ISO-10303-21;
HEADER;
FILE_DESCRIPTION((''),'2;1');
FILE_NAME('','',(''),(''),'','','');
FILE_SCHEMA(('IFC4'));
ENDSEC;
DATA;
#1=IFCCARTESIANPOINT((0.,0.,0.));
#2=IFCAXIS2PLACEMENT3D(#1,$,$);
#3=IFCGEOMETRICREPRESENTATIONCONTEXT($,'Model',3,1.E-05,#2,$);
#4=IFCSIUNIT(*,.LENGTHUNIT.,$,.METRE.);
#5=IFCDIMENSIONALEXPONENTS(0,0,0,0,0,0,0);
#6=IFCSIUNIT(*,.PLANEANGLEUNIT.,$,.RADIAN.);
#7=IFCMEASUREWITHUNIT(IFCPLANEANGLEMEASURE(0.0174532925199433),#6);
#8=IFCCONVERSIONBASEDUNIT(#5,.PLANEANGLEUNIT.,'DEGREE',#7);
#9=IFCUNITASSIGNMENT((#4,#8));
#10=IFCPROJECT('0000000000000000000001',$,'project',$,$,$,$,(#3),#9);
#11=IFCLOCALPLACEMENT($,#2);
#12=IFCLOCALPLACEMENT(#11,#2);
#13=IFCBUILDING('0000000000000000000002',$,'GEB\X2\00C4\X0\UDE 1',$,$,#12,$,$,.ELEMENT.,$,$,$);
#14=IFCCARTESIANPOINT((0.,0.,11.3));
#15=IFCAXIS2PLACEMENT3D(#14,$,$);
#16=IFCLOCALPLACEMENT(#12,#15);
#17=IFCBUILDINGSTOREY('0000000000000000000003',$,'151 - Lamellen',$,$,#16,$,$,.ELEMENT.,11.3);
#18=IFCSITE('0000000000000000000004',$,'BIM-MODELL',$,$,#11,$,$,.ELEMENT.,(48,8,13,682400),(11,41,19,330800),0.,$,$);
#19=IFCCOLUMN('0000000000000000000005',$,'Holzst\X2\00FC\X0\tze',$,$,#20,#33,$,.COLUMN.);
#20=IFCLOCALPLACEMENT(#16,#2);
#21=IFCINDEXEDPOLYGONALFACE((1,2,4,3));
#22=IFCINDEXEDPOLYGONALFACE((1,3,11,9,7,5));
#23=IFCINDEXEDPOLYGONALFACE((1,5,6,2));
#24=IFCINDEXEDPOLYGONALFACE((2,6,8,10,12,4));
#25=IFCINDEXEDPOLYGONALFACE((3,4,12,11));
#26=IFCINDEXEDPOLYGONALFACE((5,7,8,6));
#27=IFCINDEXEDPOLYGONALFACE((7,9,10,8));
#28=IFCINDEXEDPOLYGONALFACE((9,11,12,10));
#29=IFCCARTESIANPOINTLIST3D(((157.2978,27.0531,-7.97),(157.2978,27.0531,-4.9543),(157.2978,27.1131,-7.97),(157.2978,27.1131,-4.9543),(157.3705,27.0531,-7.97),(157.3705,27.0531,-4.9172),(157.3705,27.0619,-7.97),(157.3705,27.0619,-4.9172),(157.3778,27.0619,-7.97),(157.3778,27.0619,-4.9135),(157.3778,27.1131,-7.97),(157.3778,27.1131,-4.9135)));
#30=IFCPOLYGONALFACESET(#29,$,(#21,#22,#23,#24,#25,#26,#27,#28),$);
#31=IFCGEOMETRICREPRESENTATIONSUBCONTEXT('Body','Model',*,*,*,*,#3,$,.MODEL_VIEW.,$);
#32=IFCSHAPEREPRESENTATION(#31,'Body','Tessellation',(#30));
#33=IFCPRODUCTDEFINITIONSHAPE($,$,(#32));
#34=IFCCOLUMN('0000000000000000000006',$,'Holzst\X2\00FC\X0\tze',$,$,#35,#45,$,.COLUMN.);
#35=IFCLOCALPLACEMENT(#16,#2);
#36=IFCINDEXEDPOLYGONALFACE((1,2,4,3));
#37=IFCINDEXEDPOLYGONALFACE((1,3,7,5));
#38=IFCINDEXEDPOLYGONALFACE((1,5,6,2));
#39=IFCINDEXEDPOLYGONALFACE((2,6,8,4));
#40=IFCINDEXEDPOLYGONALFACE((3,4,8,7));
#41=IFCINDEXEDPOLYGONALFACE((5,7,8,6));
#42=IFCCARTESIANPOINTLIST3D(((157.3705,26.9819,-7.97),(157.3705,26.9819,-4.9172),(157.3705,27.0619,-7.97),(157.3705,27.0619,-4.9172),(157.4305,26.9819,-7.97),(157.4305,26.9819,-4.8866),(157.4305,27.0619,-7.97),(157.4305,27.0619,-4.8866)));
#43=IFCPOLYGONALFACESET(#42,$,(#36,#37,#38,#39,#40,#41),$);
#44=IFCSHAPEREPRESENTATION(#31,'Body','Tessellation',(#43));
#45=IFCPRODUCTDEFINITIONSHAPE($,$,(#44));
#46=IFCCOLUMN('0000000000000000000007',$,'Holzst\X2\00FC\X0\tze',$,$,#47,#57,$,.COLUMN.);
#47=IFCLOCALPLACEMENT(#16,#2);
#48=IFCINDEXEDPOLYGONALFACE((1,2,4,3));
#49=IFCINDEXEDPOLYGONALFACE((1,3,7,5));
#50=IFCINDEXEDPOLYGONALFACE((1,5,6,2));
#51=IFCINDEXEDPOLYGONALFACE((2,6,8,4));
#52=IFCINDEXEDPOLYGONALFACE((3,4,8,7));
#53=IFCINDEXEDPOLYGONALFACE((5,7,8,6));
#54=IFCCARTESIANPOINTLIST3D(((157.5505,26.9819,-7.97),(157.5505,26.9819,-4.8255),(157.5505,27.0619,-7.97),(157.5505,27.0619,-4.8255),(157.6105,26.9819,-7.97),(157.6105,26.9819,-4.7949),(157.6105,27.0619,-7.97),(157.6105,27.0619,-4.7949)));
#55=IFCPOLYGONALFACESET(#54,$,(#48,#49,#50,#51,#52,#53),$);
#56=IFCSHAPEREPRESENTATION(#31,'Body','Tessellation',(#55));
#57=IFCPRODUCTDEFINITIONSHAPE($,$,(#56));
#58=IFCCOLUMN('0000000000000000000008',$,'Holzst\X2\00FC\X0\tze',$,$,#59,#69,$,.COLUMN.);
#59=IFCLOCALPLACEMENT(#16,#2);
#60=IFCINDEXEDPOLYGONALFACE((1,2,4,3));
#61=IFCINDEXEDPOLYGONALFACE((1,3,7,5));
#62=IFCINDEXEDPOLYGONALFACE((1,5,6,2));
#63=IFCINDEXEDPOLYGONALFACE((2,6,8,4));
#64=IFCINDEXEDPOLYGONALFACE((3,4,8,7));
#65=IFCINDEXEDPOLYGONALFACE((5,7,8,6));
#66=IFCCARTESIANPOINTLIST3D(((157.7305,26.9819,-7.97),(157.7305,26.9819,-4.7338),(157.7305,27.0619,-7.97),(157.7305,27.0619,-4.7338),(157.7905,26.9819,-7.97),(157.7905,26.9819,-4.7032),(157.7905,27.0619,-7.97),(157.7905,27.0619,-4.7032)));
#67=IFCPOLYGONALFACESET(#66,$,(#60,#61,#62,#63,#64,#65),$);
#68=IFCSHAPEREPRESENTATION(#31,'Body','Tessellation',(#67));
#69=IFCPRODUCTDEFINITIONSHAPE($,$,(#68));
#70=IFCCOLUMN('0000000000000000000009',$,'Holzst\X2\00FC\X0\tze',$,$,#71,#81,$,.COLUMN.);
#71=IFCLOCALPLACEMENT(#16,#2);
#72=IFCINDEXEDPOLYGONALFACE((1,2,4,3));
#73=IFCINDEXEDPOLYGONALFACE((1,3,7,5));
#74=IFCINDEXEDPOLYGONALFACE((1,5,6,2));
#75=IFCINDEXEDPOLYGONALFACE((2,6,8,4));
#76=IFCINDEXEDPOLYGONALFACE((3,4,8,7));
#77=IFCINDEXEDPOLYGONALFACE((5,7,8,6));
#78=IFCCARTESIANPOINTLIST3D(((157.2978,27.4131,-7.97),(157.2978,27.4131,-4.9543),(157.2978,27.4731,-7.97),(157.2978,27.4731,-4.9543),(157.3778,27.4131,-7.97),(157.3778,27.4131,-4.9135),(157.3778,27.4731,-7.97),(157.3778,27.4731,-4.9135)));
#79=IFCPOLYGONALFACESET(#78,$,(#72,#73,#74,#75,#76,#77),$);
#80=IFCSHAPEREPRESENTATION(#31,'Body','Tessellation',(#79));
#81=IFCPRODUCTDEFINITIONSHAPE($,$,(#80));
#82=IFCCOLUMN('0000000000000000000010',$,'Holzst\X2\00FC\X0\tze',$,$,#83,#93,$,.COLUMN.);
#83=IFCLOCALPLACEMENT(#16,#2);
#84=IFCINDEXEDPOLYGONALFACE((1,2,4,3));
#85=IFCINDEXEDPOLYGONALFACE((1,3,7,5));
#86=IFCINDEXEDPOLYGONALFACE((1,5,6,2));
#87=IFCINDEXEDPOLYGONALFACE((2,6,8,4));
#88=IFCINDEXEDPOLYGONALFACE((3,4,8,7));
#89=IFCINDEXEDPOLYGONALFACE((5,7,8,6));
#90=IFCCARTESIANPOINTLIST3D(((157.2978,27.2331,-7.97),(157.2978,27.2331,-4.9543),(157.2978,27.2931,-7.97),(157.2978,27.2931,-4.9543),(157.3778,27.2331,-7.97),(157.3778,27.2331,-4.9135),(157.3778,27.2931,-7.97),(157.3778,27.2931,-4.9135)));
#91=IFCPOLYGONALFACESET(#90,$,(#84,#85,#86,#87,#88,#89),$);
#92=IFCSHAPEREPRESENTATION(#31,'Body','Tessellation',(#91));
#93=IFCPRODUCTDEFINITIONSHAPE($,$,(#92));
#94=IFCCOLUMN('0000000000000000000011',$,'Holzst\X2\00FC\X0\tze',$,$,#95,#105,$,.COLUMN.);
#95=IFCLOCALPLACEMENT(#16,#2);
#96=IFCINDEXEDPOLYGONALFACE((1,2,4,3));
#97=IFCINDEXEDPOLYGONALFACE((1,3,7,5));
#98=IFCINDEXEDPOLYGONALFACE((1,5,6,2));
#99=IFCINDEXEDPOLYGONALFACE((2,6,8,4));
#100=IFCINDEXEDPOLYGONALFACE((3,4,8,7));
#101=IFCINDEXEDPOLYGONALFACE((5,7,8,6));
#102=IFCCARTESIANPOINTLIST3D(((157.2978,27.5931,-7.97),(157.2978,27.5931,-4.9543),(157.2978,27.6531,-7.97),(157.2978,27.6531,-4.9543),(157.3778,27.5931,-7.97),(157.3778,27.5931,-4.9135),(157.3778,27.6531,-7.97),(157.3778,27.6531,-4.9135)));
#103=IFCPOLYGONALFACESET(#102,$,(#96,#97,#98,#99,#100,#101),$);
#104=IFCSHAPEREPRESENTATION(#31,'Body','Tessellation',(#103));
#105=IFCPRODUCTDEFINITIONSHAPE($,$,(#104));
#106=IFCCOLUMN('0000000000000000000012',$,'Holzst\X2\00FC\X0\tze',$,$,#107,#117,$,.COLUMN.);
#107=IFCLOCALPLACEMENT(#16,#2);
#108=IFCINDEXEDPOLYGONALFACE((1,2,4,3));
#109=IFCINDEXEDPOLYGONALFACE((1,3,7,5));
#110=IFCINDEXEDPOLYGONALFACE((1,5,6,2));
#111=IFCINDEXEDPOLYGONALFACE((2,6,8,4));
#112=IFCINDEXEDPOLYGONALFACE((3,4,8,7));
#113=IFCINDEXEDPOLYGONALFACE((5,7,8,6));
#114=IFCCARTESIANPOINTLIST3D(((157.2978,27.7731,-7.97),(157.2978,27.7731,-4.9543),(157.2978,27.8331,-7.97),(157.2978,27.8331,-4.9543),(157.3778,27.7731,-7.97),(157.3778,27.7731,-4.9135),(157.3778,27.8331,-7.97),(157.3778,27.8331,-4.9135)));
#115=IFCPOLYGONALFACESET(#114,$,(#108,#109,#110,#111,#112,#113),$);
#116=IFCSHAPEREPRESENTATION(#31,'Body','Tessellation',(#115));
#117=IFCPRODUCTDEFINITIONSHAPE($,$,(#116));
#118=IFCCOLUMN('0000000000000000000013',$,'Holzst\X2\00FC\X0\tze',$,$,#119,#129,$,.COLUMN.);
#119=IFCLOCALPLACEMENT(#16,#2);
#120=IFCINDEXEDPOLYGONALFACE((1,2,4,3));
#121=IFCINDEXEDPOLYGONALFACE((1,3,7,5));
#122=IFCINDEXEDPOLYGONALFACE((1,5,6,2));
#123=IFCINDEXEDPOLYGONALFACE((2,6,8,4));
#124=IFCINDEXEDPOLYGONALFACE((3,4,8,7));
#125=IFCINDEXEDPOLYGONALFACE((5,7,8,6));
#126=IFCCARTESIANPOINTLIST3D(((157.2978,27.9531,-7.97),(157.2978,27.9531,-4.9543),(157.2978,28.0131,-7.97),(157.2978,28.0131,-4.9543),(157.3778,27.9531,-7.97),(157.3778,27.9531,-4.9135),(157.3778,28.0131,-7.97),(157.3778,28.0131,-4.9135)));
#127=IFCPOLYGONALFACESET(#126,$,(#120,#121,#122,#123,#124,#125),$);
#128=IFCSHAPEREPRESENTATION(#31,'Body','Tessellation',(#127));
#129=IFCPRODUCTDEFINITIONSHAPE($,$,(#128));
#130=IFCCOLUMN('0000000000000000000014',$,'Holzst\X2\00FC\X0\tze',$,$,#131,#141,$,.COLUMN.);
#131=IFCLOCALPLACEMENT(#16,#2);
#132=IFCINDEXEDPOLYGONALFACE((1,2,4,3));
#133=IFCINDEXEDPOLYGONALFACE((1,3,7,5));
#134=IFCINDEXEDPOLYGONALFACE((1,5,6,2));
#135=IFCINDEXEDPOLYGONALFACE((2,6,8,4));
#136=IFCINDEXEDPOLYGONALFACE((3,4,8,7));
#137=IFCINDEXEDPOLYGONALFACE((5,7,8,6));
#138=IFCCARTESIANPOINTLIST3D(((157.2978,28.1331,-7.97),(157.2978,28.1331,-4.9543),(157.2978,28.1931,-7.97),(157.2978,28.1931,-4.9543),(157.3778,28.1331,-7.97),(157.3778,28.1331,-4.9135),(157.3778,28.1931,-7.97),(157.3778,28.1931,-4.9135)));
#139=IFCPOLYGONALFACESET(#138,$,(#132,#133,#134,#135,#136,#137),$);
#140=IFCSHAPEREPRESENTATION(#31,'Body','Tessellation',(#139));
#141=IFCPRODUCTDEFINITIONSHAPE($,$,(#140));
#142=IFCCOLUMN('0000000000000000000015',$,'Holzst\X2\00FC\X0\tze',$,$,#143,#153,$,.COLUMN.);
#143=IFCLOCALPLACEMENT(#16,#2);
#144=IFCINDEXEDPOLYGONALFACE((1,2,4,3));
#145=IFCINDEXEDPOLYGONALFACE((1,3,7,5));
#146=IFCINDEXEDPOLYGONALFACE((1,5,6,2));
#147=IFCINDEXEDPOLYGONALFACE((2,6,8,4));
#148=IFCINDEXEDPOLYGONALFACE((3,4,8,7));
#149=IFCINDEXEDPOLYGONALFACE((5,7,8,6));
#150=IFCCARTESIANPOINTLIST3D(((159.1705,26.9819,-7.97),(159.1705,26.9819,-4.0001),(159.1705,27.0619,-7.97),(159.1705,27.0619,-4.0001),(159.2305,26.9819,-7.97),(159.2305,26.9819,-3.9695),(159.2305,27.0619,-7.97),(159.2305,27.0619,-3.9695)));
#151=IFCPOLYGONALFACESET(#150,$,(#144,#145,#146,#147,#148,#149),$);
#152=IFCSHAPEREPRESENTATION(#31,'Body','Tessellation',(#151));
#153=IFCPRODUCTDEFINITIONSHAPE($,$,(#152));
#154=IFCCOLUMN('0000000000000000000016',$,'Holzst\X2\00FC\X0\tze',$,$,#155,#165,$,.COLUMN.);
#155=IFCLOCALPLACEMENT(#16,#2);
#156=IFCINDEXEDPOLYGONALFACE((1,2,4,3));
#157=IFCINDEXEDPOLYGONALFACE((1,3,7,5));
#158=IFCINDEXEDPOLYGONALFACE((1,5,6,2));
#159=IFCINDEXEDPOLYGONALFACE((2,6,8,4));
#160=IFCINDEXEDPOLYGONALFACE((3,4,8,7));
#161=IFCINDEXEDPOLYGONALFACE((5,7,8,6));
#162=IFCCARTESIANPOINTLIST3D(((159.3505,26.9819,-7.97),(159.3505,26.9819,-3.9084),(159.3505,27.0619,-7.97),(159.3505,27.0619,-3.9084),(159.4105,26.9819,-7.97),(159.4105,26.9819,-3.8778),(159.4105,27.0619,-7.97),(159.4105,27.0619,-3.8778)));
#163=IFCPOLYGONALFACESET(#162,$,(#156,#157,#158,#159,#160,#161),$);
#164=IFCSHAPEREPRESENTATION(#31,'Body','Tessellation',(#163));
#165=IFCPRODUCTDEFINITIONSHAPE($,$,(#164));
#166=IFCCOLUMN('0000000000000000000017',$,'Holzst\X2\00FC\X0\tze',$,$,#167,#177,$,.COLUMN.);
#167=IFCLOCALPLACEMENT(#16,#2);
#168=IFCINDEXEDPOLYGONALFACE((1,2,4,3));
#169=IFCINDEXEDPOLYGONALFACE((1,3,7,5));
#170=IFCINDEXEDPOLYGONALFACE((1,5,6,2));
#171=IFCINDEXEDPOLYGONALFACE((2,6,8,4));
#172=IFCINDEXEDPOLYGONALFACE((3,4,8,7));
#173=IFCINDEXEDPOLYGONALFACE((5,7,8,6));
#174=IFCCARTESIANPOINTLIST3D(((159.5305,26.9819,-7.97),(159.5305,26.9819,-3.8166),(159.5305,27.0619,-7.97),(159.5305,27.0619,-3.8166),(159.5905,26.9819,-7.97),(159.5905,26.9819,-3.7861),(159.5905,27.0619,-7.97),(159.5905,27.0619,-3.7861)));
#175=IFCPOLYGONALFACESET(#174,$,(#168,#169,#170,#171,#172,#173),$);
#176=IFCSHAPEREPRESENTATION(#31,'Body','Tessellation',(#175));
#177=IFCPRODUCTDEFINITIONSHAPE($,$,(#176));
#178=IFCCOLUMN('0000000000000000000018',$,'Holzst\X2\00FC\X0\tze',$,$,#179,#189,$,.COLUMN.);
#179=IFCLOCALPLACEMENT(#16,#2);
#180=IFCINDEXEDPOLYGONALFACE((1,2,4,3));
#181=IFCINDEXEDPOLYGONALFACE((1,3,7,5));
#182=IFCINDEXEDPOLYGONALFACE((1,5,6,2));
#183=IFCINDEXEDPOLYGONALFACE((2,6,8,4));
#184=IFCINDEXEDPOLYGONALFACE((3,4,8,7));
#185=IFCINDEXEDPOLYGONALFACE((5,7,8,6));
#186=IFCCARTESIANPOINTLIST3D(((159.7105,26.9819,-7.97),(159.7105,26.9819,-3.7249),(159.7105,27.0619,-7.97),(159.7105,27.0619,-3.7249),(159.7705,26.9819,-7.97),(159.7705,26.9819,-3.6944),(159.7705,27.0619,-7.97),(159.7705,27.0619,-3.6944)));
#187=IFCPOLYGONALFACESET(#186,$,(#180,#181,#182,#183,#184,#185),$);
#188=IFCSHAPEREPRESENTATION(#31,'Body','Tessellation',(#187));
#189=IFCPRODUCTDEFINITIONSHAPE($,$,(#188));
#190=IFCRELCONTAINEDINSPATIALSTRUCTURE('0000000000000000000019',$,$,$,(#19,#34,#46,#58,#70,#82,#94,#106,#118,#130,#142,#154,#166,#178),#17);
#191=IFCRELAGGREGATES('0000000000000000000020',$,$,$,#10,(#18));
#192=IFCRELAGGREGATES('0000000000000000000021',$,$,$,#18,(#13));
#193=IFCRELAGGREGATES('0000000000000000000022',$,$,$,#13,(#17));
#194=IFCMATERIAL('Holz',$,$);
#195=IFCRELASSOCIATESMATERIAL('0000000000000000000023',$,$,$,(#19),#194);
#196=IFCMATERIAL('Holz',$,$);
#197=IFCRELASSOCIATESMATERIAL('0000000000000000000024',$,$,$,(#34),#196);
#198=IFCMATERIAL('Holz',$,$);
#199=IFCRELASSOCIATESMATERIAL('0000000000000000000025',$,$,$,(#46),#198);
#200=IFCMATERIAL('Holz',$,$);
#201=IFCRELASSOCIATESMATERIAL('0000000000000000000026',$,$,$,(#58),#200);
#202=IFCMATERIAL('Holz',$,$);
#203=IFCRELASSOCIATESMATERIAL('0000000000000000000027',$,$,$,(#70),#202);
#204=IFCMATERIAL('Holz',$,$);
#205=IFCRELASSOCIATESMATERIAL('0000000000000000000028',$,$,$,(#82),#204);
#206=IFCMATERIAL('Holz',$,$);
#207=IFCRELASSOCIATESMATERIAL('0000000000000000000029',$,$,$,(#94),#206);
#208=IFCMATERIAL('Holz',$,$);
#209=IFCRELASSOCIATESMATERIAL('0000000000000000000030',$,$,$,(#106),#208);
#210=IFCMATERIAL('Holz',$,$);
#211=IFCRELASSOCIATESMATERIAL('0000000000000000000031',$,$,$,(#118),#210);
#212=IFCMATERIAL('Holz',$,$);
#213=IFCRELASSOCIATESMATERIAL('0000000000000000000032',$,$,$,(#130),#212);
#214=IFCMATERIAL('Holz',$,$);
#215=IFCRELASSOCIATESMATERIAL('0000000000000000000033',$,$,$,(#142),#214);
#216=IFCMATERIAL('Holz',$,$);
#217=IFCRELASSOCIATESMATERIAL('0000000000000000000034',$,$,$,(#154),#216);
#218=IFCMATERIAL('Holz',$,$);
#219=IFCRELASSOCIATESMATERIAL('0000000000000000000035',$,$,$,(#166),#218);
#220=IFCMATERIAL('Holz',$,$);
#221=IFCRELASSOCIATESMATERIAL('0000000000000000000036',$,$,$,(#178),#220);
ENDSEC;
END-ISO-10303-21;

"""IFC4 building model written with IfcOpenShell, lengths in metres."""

from ifc_helpers import new_model, entity, si_unit, converted_unit, frame, frame_2d, origin, origin_with_axes, place, context, subcontext, project, spatial, polyline, rectangle, outline, extrude, clip, halfspace, material, element, save


model = new_model("IFC4")

# Units and contexts
model_context = context("Model", 3, precision=1e-05, world=origin())
body_context = subcontext(model_context, "Body", "Model", "MODEL_VIEW")
ifc_project = project(units=[si_unit("LENGTHUNIT", "METRE"), converted_unit("PLANEANGLEUNIT", "DEGREE", entity("IfcPlaneAngleMeasure", 0.0174532925199433), si_unit("PLANEANGLEUNIT", "RADIAN"), dimensions=[0, 0, 0, 0, 0, 0, 0])], contexts=[model_context])

# Site, building, storey
site_placement = place(None, origin())
site = spatial("IfcSite", under=ifc_project, at=site_placement, Name="BIM-MODELL", CompositionType="ELEMENT", RefLatitude=(48, 8, 13, 682400), RefLongitude=(11, 41, 19, 330800), RefElevation=0.0)
building_placement = place(site_placement, origin())
building = spatial("IfcBuilding", under=site, at=building_placement, Name="GEBÄUDE 1", CompositionType="ELEMENT")
storey_placement = place(building_placement, frame((0.0, 0.0, 11.3)))
storey = spatial("IfcBuildingStorey", under=building, at=storey_placement, Name="151 - Lamellen", CompositionType="ELEMENT", Elevation=11.3)

# Columns
ifc_material_1 = material(Name="Holz")
column_1_placement = place(storey_placement, frame((157.2978, 27.0531, -7.97)))
element("IfcColumn", 1, at=column_1_placement, inside=storey, material=ifc_material_1, Name="Holzstütze", PredefinedType="COLUMN", context=body_context, shape_type="Clipping", body=[
    clip(extrude(outline(polyline([(0.08, 0.0088), (0.08, 0.06), (0.0, 0.06), (0.0, 0.0), (0.0728, 0.0), (0.0728, 0.0088), (0.08, 0.0088)])), origin_with_axes(), (0.0, 0.0, 1.0), 3.0565), halfspace(frame((0.0509, 0.0229, 3.0417), z_axis=(0.45399, 0.0, -0.891007), x_axis=(-0.891007, 0.0, -0.45399)), True)),
])
ifc_material_2 = material(Name="Holz")
column_2_placement = place(storey_placement, frame((157.3705, 26.9819, -7.97)))
element("IfcColumn", 2, at=column_2_placement, inside=storey, material=ifc_material_2, Name="Holzstütze", PredefinedType="COLUMN", context=body_context, shape_type="Clipping", body=[
    clip(extrude(rectangle(XDim=0.06, YDim=0.08, at=frame_2d((0.03, 0.04), x_axis=(1.0, 0.0))), origin_with_axes(), (0.0, 0.0, 1.0), 3.0834), halfspace(frame((0.03, 0.04, 3.0681), z_axis=(0.45399, 0.0, -0.891007), x_axis=(0.0, -1.0, 0.0)), True)),
])
ifc_material_3 = material(Name="Holz")
column_3_placement = place(storey_placement, frame((157.5505, 26.9819, -7.97)))
element("IfcColumn", 3, at=column_3_placement, inside=storey, material=ifc_material_3, Name="Holzstütze", PredefinedType="COLUMN", context=body_context, shape_type="Clipping", body=[
    clip(extrude(rectangle(XDim=0.06, YDim=0.08, at=frame_2d((0.03, 0.04), x_axis=(1.0, 0.0))), origin_with_axes(), (0.0, 0.0, 1.0), 3.1751), halfspace(frame((0.03, 0.04, 3.1598), z_axis=(0.45399, 0.0, -0.891007), x_axis=(0.0, -1.0, 0.0)), True)),
])
ifc_material_4 = material(Name="Holz")
column_4_placement = place(storey_placement, frame((157.7305, 26.9819, -7.97)))
element("IfcColumn", 4, at=column_4_placement, inside=storey, material=ifc_material_4, Name="Holzstütze", PredefinedType="COLUMN", context=body_context, shape_type="Clipping", body=[
    clip(extrude(rectangle(XDim=0.06, YDim=0.08, at=frame_2d((0.03, 0.04), x_axis=(1.0, 0.0))), origin_with_axes(), (0.0, 0.0, 1.0), 3.2668), halfspace(frame((0.03, 0.04, 3.2515), z_axis=(0.45399, 0.0, -0.891007), x_axis=(0.0, -1.0, 0.0)), True)),
])
ifc_material_5 = material(Name="Holz")
column_5_placement = place(storey_placement, frame((157.3778, 27.4131, -7.97)))
element("IfcColumn", 5, at=column_5_placement, inside=storey, material=ifc_material_5, Name="Holzstütze", PredefinedType="COLUMN", context=body_context, shape_type="Clipping", body=[
    clip(extrude(rectangle(XDim=0.06, YDim=0.08, at=frame_2d((-0.04, 0.03), x_axis=(0.0, 1.0))), origin_with_axes(), (0.0, 0.0, 1.0), 3.0565), halfspace(frame((-0.04, 0.03, 3.0361), z_axis=(0.45399, 0.0, -0.891007), x_axis=(-0.891007, 0.0, -0.45399)), True)),
])
ifc_material_6 = material(Name="Holz")
column_6_placement = place(storey_placement, frame((157.3778, 27.2331, -7.97)))
element("IfcColumn", 6, at=column_6_placement, inside=storey, material=ifc_material_6, Name="Holzstütze", PredefinedType="COLUMN", context=body_context, shape_type="Clipping", body=[
    clip(extrude(rectangle(XDim=0.06, YDim=0.08, at=frame_2d((-0.04, 0.03), x_axis=(0.0, 1.0))), origin_with_axes(), (0.0, 0.0, 1.0), 3.0565), halfspace(frame((-0.04, 0.03, 3.0361), z_axis=(0.45399, 0.0, -0.891007), x_axis=(-0.891007, 0.0, -0.45399)), True)),
])
ifc_material_7 = material(Name="Holz")
column_7_placement = place(storey_placement, frame((157.3778, 27.5931, -7.97)))
element("IfcColumn", 7, at=column_7_placement, inside=storey, material=ifc_material_7, Name="Holzstütze", PredefinedType="COLUMN", context=body_context, shape_type="Clipping", body=[
    clip(extrude(rectangle(XDim=0.06, YDim=0.08, at=frame_2d((-0.04, 0.03), x_axis=(0.0, 1.0))), origin_with_axes(), (0.0, 0.0, 1.0), 3.0565), halfspace(frame((-0.04, 0.03, 3.0361), z_axis=(0.45399, 0.0, -0.891007), x_axis=(-0.891007, 0.0, -0.45399)), True)),
])
ifc_material_8 = material(Name="Holz")
column_8_placement = place(storey_placement, frame((157.3778, 27.7731, -7.97)))
element("IfcColumn", 8, at=column_8_placement, inside=storey, material=ifc_material_8, Name="Holzstütze", PredefinedType="COLUMN", context=body_context, shape_type="Clipping", body=[
    clip(extrude(rectangle(XDim=0.06, YDim=0.08, at=frame_2d((-0.04, 0.03), x_axis=(0.0, 1.0))), origin_with_axes(), (0.0, 0.0, 1.0), 3.0565), halfspace(frame((-0.04, 0.03, 3.0361), z_axis=(0.45399, 0.0, -0.891007), x_axis=(-0.891007, 0.0, -0.45399)), True)),
])
ifc_material_9 = material(Name="Holz")
column_9_placement = place(storey_placement, frame((157.3778, 27.9531, -7.97)))
element("IfcColumn", 9, at=column_9_placement, inside=storey, material=ifc_material_9, Name="Holzstütze", PredefinedType="COLUMN", context=body_context, shape_type="Clipping", body=[
    clip(extrude(rectangle(XDim=0.06, YDim=0.08, at=frame_2d((-0.04, 0.03), x_axis=(0.0, 1.0))), origin_with_axes(), (0.0, 0.0, 1.0), 3.0565), halfspace(frame((-0.04, 0.03, 3.0361), z_axis=(0.45399, 0.0, -0.891007), x_axis=(-0.891007, 0.0, -0.45399)), True)),
])
ifc_material_10 = material(Name="Holz")
column_10_placement = place(storey_placement, frame((157.3778, 28.1331, -7.97)))
element("IfcColumn", 10, at=column_10_placement, inside=storey, material=ifc_material_10, Name="Holzstütze", PredefinedType="COLUMN", context=body_context, shape_type="Clipping", body=[
    clip(extrude(rectangle(XDim=0.06, YDim=0.08, at=frame_2d((-0.04, 0.03), x_axis=(0.0, 1.0))), origin_with_axes(), (0.0, 0.0, 1.0), 3.0565), halfspace(frame((-0.04, 0.03, 3.0361), z_axis=(0.45399, 0.0, -0.891007), x_axis=(-0.891007, 0.0, -0.45399)), True)),
])
ifc_material_11 = material(Name="Holz")
column_11_placement = place(storey_placement, frame((159.1705, 26.9819, -7.97)))
element("IfcColumn", 11, at=column_11_placement, inside=storey, material=ifc_material_11, Name="Holzstütze", PredefinedType="COLUMN", context=body_context, shape_type="Clipping", body=[
    clip(extrude(rectangle(XDim=0.06, YDim=0.08, at=frame_2d((0.03, 0.04), x_axis=(1.0, 0.0))), origin_with_axes(), (0.0, 0.0, 1.0), 4.0005), halfspace(frame((0.03, 0.04, 3.9852), z_axis=(0.45399, 0.0, -0.891007), x_axis=(0.0, -1.0, 0.0)), True)),
])
ifc_material_12 = material(Name="Holz")
column_12_placement = place(storey_placement, frame((159.3505, 26.9819, -7.97)))
element("IfcColumn", 12, at=column_12_placement, inside=storey, material=ifc_material_12, Name="Holzstütze", PredefinedType="COLUMN", context=body_context, shape_type="Clipping", body=[
    clip(extrude(rectangle(XDim=0.06, YDim=0.08, at=frame_2d((0.03, 0.04), x_axis=(1.0, 0.0))), origin_with_axes(), (0.0, 0.0, 1.0), 4.0922), halfspace(frame((0.03, 0.04, 4.0769), z_axis=(0.45399, 0.0, -0.891007), x_axis=(0.0, -1.0, 0.0)), True)),
])
ifc_material_13 = material(Name="Holz")
column_13_placement = place(storey_placement, frame((159.5305, 26.9819, -7.97)))
element("IfcColumn", 13, at=column_13_placement, inside=storey, material=ifc_material_13, Name="Holzstütze", PredefinedType="COLUMN", context=body_context, shape_type="Clipping", body=[
    clip(extrude(rectangle(XDim=0.06, YDim=0.08, at=frame_2d((0.03, 0.04), x_axis=(1.0, 0.0))), origin_with_axes(), (0.0, 0.0, 1.0), 4.1839), halfspace(frame((0.03, 0.04, 4.1686), z_axis=(0.45399, 0.0, -0.891007), x_axis=(0.0, -1.0, 0.0)), True)),
])
ifc_material_14 = material(Name="Holz")
column_14_placement = place(storey_placement, frame((159.7105, 26.9819, -7.97)))
element("IfcColumn", 14, at=column_14_placement, inside=storey, material=ifc_material_14, Name="Holzstütze", PredefinedType="COLUMN", context=body_context, shape_type="Clipping", body=[
    clip(extrude(rectangle(XDim=0.06, YDim=0.08, at=frame_2d((0.03, 0.04), x_axis=(1.0, 0.0))), origin_with_axes(), (0.0, 0.0, 1.0), 4.2756), halfspace(frame((0.03, 0.04, 4.2604), z_axis=(0.45399, 0.0, -0.891007), x_axis=(0.0, -1.0, 0.0)), True)),
])

save(model, "model.ifc")
